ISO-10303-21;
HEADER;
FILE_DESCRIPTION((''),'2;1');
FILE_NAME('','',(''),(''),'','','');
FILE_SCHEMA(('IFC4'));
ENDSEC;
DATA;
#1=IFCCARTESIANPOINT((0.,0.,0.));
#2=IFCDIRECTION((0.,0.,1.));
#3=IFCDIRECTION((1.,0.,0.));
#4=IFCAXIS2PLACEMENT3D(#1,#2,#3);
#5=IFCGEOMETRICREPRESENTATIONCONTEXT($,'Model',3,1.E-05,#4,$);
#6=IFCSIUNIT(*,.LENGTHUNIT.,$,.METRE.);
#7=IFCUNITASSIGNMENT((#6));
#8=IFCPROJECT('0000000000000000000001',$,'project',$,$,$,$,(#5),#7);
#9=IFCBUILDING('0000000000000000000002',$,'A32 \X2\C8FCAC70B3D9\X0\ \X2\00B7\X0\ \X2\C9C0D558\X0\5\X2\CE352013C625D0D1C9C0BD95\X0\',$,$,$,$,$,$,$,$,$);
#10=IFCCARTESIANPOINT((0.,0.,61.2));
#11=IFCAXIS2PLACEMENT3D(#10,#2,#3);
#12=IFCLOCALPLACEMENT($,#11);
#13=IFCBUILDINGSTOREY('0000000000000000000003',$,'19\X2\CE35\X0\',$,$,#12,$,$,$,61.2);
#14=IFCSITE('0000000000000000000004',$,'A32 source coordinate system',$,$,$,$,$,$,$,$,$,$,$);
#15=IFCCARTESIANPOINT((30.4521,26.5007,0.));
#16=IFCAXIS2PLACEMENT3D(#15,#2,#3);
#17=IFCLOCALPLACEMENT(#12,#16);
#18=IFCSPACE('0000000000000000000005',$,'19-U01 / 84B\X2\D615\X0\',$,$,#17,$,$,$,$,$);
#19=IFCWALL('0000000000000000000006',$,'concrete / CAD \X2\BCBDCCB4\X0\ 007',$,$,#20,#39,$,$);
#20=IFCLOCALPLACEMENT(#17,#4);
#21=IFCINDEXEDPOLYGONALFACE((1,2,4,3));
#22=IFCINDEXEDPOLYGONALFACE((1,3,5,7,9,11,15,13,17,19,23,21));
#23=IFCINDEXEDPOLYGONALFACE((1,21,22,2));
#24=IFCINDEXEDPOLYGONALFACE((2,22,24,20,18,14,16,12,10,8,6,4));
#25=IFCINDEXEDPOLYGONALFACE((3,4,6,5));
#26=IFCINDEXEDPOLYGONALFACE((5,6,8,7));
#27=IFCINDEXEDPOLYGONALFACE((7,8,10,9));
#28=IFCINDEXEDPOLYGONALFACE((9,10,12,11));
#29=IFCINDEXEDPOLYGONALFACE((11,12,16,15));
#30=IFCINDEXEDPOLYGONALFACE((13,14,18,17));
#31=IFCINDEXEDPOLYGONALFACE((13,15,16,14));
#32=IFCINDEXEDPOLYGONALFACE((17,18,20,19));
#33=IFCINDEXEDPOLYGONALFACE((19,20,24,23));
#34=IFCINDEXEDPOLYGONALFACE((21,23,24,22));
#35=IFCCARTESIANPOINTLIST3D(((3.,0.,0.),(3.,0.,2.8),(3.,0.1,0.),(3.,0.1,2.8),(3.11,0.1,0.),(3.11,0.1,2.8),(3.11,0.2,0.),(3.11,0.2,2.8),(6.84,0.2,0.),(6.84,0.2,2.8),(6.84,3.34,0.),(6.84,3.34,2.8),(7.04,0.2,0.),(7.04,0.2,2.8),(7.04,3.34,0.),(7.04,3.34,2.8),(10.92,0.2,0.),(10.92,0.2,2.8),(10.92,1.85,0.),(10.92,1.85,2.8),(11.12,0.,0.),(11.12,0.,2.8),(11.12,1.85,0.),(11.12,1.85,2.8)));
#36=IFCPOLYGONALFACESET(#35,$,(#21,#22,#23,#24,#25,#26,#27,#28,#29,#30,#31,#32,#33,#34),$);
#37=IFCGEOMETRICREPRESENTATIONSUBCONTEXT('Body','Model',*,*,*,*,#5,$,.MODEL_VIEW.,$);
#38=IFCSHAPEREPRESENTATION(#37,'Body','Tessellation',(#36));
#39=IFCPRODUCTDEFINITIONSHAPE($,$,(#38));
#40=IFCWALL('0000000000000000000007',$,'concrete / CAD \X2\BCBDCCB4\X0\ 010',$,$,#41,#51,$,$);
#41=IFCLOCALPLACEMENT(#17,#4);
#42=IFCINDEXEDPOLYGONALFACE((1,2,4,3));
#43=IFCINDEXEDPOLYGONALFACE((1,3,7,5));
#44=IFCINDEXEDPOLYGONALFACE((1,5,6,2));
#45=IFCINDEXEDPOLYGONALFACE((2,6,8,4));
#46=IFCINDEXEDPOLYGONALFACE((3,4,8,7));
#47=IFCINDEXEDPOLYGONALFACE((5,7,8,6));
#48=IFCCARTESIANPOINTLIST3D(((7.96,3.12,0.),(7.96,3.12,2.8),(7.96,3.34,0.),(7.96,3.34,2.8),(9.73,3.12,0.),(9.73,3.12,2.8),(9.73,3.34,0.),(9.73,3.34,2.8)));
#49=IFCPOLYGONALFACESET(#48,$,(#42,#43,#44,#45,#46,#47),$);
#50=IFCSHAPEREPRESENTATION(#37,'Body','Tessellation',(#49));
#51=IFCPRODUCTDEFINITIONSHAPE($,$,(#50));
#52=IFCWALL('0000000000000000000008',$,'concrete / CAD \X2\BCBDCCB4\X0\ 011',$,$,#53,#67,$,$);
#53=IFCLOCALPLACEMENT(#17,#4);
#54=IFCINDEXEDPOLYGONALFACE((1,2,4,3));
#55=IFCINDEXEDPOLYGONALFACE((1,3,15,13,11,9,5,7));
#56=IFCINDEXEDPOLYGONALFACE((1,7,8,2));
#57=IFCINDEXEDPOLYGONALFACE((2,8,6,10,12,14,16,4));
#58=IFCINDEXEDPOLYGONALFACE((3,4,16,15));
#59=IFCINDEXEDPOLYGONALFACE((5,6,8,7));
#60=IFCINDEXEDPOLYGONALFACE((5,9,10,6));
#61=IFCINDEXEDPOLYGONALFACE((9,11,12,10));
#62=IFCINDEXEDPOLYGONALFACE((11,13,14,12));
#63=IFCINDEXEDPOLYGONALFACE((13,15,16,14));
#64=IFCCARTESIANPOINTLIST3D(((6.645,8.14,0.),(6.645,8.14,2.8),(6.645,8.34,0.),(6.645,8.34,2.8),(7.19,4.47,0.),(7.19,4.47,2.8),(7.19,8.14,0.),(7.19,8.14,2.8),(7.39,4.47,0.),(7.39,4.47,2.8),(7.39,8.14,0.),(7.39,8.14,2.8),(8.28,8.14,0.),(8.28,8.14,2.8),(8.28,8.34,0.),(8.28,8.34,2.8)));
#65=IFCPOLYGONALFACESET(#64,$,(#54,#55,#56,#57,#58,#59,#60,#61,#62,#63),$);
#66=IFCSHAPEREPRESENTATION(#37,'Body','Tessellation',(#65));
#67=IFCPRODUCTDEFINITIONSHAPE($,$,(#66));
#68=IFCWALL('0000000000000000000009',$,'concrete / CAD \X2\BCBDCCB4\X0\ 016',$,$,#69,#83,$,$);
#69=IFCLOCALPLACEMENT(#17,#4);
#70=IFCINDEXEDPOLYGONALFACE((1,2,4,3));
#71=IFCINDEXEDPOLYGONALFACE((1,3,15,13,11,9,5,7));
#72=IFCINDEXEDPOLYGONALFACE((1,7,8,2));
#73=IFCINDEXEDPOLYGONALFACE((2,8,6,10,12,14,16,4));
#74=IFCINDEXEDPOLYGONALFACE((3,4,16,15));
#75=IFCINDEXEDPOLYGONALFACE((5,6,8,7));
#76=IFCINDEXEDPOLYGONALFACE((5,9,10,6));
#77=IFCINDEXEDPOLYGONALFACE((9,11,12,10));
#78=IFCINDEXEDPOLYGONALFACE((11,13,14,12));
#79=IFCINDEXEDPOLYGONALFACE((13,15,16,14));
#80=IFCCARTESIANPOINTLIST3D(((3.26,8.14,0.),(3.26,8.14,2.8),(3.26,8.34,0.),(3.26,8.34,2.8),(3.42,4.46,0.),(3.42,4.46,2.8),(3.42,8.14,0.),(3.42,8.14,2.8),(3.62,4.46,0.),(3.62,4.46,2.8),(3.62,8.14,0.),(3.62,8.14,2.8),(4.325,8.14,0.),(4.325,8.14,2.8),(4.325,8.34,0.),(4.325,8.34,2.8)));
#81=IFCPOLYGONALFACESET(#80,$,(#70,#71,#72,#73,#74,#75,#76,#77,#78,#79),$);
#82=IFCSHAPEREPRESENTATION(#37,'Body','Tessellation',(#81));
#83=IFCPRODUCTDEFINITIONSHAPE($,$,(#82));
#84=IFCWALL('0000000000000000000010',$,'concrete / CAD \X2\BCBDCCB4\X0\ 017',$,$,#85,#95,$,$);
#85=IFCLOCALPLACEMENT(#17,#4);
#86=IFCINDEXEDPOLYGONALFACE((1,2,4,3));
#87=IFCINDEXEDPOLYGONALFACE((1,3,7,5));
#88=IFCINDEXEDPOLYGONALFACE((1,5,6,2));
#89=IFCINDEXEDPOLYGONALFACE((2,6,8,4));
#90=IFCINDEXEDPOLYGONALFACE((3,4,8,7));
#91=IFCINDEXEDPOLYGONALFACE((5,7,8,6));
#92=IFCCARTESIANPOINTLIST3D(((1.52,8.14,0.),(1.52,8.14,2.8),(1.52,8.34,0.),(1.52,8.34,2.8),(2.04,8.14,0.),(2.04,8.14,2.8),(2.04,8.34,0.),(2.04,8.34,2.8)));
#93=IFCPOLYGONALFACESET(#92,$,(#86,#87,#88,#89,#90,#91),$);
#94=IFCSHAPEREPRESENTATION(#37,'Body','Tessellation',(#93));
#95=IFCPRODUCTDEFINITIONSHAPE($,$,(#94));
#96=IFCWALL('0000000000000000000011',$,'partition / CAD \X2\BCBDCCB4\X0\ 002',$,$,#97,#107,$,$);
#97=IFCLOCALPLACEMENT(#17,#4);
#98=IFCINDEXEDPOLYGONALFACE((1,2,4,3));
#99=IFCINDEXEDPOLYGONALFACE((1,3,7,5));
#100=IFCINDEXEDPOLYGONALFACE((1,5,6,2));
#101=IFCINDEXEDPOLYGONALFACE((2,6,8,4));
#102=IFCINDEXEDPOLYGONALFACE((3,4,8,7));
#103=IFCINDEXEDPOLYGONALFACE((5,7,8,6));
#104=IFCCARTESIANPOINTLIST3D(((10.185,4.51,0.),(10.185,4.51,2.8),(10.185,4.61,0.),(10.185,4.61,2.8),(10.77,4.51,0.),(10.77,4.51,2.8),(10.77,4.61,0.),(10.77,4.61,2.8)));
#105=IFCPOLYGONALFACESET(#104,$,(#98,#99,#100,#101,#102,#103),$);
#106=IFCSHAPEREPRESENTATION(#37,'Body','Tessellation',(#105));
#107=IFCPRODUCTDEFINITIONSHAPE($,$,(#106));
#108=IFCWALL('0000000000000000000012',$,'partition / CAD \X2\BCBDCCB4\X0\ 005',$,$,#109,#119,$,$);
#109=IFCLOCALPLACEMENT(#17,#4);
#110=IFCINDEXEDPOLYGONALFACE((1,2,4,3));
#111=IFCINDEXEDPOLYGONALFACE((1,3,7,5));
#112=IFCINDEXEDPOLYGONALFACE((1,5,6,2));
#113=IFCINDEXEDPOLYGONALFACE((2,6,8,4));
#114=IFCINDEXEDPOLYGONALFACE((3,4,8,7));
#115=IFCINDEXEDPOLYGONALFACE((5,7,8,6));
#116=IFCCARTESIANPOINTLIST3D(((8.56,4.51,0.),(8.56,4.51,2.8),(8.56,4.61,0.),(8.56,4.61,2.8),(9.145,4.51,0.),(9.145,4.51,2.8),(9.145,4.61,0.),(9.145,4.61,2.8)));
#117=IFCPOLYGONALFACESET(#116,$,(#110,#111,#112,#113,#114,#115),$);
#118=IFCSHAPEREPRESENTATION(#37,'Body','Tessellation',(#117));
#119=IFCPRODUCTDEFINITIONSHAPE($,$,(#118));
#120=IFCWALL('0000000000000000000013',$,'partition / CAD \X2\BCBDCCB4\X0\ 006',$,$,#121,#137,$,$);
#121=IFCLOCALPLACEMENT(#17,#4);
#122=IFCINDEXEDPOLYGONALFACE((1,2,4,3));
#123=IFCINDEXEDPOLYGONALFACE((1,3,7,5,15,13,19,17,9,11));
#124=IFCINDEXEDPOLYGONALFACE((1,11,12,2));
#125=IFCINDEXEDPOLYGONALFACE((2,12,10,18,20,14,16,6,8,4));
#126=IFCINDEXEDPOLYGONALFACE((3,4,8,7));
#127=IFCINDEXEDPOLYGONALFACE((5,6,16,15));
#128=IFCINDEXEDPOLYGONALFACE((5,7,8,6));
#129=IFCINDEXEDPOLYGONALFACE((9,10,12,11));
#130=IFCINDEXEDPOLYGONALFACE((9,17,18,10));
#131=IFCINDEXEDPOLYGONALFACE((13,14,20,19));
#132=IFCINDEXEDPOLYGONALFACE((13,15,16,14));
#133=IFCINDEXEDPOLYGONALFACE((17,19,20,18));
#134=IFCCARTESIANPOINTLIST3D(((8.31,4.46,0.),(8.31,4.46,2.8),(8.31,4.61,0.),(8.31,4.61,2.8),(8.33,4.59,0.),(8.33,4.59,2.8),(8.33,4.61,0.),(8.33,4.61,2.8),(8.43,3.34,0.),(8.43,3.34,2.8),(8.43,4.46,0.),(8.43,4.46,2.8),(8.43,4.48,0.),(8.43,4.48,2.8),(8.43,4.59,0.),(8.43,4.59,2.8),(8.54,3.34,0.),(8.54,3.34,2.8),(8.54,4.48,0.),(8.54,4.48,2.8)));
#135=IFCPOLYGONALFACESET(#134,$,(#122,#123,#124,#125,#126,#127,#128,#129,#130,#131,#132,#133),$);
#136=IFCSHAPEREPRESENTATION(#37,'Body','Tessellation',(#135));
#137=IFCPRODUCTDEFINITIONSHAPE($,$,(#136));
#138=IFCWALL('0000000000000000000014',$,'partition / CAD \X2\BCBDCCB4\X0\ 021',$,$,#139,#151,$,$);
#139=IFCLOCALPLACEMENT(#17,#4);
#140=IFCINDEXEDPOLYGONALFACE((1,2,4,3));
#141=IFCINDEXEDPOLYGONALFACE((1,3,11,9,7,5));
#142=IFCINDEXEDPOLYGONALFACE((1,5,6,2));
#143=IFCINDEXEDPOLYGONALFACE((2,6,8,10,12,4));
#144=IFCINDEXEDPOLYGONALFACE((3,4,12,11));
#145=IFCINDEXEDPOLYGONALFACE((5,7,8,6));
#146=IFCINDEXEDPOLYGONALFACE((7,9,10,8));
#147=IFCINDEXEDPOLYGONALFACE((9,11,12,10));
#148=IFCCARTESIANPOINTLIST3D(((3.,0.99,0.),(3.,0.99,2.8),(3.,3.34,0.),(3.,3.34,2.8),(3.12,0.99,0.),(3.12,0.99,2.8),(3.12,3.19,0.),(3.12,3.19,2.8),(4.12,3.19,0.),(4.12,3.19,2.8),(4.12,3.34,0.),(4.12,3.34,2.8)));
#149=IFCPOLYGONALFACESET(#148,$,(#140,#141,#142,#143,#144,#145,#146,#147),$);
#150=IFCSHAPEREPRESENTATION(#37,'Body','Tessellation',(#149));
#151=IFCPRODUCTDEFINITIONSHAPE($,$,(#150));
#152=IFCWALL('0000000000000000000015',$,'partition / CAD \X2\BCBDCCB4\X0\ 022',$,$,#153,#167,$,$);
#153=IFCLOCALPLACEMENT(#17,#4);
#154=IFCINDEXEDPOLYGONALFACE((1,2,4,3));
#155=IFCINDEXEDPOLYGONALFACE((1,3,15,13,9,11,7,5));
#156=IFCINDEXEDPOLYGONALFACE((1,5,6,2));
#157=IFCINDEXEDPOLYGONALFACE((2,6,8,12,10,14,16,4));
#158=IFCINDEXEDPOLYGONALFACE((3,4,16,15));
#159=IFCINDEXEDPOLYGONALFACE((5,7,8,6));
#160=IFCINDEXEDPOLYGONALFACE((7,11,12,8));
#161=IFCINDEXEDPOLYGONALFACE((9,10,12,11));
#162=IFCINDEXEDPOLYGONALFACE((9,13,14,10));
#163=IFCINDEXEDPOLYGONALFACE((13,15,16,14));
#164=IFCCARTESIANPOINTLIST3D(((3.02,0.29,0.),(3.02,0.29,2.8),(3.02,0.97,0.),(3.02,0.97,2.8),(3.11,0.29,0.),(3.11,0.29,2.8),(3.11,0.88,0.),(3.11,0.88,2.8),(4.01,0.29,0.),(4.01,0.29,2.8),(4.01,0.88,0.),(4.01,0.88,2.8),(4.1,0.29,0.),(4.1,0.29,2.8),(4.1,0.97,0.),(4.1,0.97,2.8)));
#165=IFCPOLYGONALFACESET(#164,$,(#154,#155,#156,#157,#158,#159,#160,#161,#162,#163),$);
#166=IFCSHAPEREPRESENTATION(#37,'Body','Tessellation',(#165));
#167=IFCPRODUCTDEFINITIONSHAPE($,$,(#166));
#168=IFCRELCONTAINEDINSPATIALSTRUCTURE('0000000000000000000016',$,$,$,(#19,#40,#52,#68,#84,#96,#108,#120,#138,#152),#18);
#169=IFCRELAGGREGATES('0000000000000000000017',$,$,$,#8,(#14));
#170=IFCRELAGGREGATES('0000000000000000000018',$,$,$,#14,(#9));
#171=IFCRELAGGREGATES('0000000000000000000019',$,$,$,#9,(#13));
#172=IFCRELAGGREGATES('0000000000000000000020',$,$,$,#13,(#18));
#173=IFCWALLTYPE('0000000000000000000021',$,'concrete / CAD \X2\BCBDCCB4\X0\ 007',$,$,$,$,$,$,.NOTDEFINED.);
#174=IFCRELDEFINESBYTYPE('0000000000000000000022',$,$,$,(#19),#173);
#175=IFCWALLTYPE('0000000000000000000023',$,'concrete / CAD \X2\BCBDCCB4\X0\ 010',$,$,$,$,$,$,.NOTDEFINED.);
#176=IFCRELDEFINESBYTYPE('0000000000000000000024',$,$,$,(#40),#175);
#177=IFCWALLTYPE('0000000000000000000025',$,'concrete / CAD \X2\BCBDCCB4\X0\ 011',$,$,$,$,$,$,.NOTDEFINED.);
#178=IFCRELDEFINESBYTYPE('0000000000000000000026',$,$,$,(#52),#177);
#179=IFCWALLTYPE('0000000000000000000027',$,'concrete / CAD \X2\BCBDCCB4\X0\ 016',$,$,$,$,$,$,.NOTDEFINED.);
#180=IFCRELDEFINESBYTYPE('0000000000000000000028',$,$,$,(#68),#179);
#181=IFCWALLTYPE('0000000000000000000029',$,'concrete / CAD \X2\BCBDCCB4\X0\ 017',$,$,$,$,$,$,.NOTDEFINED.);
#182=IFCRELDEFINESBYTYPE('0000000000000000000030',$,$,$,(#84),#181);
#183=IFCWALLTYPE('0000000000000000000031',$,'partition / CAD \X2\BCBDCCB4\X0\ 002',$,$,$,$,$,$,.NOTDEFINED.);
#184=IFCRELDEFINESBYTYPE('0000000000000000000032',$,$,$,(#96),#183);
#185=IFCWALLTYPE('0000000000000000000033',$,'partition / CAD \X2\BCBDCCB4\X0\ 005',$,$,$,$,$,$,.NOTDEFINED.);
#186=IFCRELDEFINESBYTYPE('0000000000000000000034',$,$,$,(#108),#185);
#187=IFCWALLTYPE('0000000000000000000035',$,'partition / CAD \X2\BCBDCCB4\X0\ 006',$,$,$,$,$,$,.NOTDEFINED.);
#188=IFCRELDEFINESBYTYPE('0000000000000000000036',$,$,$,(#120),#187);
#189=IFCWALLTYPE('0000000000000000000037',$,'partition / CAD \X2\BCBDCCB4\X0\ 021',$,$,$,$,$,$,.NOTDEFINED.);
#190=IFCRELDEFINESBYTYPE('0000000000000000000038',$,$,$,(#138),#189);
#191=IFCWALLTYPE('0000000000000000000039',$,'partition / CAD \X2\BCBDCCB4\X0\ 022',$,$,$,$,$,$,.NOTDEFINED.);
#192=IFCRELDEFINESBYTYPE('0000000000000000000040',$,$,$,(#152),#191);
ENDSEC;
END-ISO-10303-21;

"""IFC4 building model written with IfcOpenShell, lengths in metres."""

from ifc_helpers import new_model, si_unit, frame, origin, origin_with_axes, place, context, subcontext, project, spatial, polyline, outline, extrude, source, transform, mapped, type_object, type_shapes, element, save


model = new_model("IFC4")

# Units and contexts
model_context = context("Model", 3, precision=1e-05, world=origin_with_axes())
body_context = subcontext(model_context, "Body", "Model", "MODEL_VIEW")
ifc_project = project(units=[si_unit("LENGTHUNIT", "METRE")], contexts=[model_context])

# Site, building, storey, space
site = spatial("IfcSite", under=ifc_project, Name="A32 source coordinate system")
building = spatial("IfcBuilding", under=site, Name="A32 주거동 · 지하5층–옥탑지붕")
storey_placement = place(None, frame((0.0, 0.0, 61.2), z_axis=(0.0, 0.0, 1.0), x_axis=(1.0, 0.0, 0.0)))
storey = spatial("IfcBuildingStorey", under=building, at=storey_placement, Name="19층", Elevation=61.2)
space_1_placement = place(storey_placement, frame((30.4521, 26.5007, 0.0), z_axis=(0.0, 0.0, 1.0), x_axis=(1.0, 0.0, 0.0)))
space_1 = spatial("IfcSpace", under=storey, at=space_1_placement, Name="19-U01 / 84B형")

# Walls
wall_type_1 = type_object("IfcWallType", Name="concrete / CAD 벽체 007", PredefinedType="NOTDEFINED")
shared_shape_1 = source(origin(), body_context, "Body", "SweptSolid", [
    extrude(outline(polyline([(3.0, 0.0), (3.0, 0.1), (3.11, 0.1), (3.11, 0.2), (6.84, 0.2), (6.84, 3.34), (7.04, 3.34), (7.04, 0.2), (10.92, 0.2), (10.92, 1.85), (11.12, 1.85), (11.12, 0.0), (3.0, 0.0)])), origin(), (0.0, 0.0, 1.0), 2.8),
])
type_shapes(wall_type_1, [shared_shape_1])
wall_1_placement = place(space_1_placement, origin_with_axes())
element("IfcWall", 1, at=wall_1_placement, inside=space_1, type_object=wall_type_1, Name="concrete / CAD 벽체 007", context=body_context, shape_type="MappedRepresentation", body=[
    mapped(shared_shape_1, transform((0.0, 0.0, 0.0), scale=1.0)),
])
wall_type_2 = type_object("IfcWallType", Name="concrete / CAD 벽체 010", PredefinedType="NOTDEFINED")
shared_shape_2 = source(origin(), body_context, "Body", "SweptSolid", [
    extrude(outline(polyline([(7.96, 3.12), (7.96, 3.34), (9.73, 3.34), (9.73, 3.12), (7.96, 3.12)])), origin(), (0.0, 0.0, 1.0), 2.8),
])
type_shapes(wall_type_2, [shared_shape_2])
wall_2_placement = place(space_1_placement, origin_with_axes())
element("IfcWall", 2, at=wall_2_placement, inside=space_1, type_object=wall_type_2, Name="concrete / CAD 벽체 010", context=body_context, shape_type="MappedRepresentation", body=[
    mapped(shared_shape_2, transform((0.0, 0.0, 0.0), scale=1.0)),
])
wall_type_3 = type_object("IfcWallType", Name="concrete / CAD 벽체 011", PredefinedType="NOTDEFINED")
shared_shape_3 = source(origin(), body_context, "Body", "SweptSolid", [
    extrude(outline(polyline([(7.19, 8.14), (6.645, 8.14), (6.645, 8.34), (8.28, 8.34), (8.28, 8.14), (7.39, 8.14), (7.39, 4.47), (7.19, 4.47), (7.19, 8.14)])), origin(), (0.0, 0.0, 1.0), 2.8),
])
type_shapes(wall_type_3, [shared_shape_3])
wall_3_placement = place(space_1_placement, origin_with_axes())
element("IfcWall", 3, at=wall_3_placement, inside=space_1, type_object=wall_type_3, Name="concrete / CAD 벽체 011", context=body_context, shape_type="MappedRepresentation", body=[
    mapped(shared_shape_3, transform((0.0, 0.0, 0.0), scale=1.0)),
])
wall_type_4 = type_object("IfcWallType", Name="concrete / CAD 벽체 016", PredefinedType="NOTDEFINED")
shared_shape_4 = source(origin(), body_context, "Body", "SweptSolid", [
    extrude(outline(polyline([(3.26, 8.14), (3.26, 8.34), (4.325, 8.34), (4.325, 8.14), (3.62, 8.14), (3.62, 4.46), (3.42, 4.46), (3.42, 8.14), (3.26, 8.14)])), origin(), (0.0, 0.0, 1.0), 2.8),
])
type_shapes(wall_type_4, [shared_shape_4])
wall_4_placement = place(space_1_placement, origin_with_axes())
element("IfcWall", 4, at=wall_4_placement, inside=space_1, type_object=wall_type_4, Name="concrete / CAD 벽체 016", context=body_context, shape_type="MappedRepresentation", body=[
    mapped(shared_shape_4, transform((0.0, 0.0, 0.0), scale=1.0)),
])
wall_type_5 = type_object("IfcWallType", Name="concrete / CAD 벽체 017", PredefinedType="NOTDEFINED")
shared_shape_5 = source(origin(), body_context, "Body", "SweptSolid", [
    extrude(outline(polyline([(1.52, 8.34), (2.04, 8.34), (2.04, 8.14), (1.52, 8.14), (1.52, 8.34)])), origin(), (0.0, 0.0, 1.0), 2.8),
])
type_shapes(wall_type_5, [shared_shape_5])
wall_5_placement = place(space_1_placement, origin_with_axes())
element("IfcWall", 5, at=wall_5_placement, inside=space_1, type_object=wall_type_5, Name="concrete / CAD 벽체 017", context=body_context, shape_type="MappedRepresentation", body=[
    mapped(shared_shape_5, transform((0.0, 0.0, 0.0), scale=1.0)),
])
wall_type_6 = type_object("IfcWallType", Name="partition / CAD 벽체 002", PredefinedType="NOTDEFINED")
shared_shape_6 = source(origin(), body_context, "Body", "SweptSolid", [
    extrude(outline(polyline([(10.185, 4.51), (10.185, 4.61), (10.77, 4.61), (10.77, 4.51), (10.185, 4.51)])), origin(), (0.0, 0.0, 1.0), 2.8),
])
type_shapes(wall_type_6, [shared_shape_6])
wall_6_placement = place(space_1_placement, origin_with_axes())
element("IfcWall", 6, at=wall_6_placement, inside=space_1, type_object=wall_type_6, Name="partition / CAD 벽체 002", context=body_context, shape_type="MappedRepresentation", body=[
    mapped(shared_shape_6, transform((0.0, 0.0, 0.0), scale=1.0)),
])
wall_type_7 = type_object("IfcWallType", Name="partition / CAD 벽체 005", PredefinedType="NOTDEFINED")
shared_shape_7 = source(origin(), body_context, "Body", "SweptSolid", [
    extrude(outline(polyline([(8.56, 4.51), (8.56, 4.61), (9.145, 4.61), (9.145, 4.51), (8.56, 4.51)])), origin(), (0.0, 0.0, 1.0), 2.8),
])
type_shapes(wall_type_7, [shared_shape_7])
wall_7_placement = place(space_1_placement, origin_with_axes())
element("IfcWall", 7, at=wall_7_placement, inside=space_1, type_object=wall_type_7, Name="partition / CAD 벽체 005", context=body_context, shape_type="MappedRepresentation", body=[
    mapped(shared_shape_7, transform((0.0, 0.0, 0.0), scale=1.0)),
])
wall_type_8 = type_object("IfcWallType", Name="partition / CAD 벽체 006", PredefinedType="NOTDEFINED")
shared_shape_8 = source(origin(), body_context, "Body", "SweptSolid", [
    extrude(outline(polyline([(8.43, 4.46), (8.31, 4.46), (8.31, 4.61), (8.33, 4.61), (8.33, 4.59), (8.43, 4.59), (8.43, 4.48), (8.54, 4.48), (8.54, 3.34), (8.43, 3.34), (8.43, 4.46)])), origin(), (0.0, 0.0, 1.0), 2.8),
])
type_shapes(wall_type_8, [shared_shape_8])
wall_8_placement = place(space_1_placement, origin_with_axes())
element("IfcWall", 8, at=wall_8_placement, inside=space_1, type_object=wall_type_8, Name="partition / CAD 벽체 006", context=body_context, shape_type="MappedRepresentation", body=[
    mapped(shared_shape_8, transform((0.0, 0.0, 0.0), scale=1.0)),
])
wall_type_9 = type_object("IfcWallType", Name="partition / CAD 벽체 021", PredefinedType="NOTDEFINED")
shared_shape_9 = source(origin(), body_context, "Body", "SweptSolid", [
    extrude(outline(polyline([(4.12, 3.34), (4.12, 3.19), (3.12, 3.19), (3.12, 0.99), (3.0, 0.99), (3.0, 3.34), (4.12, 3.34)])), origin(), (0.0, 0.0, 1.0), 2.8),
])
type_shapes(wall_type_9, [shared_shape_9])
wall_9_placement = place(space_1_placement, origin_with_axes())
element("IfcWall", 9, at=wall_9_placement, inside=space_1, type_object=wall_type_9, Name="partition / CAD 벽체 021", context=body_context, shape_type="MappedRepresentation", body=[
    mapped(shared_shape_9, transform((0.0, 0.0, 0.0), scale=1.0)),
])
wall_type_10 = type_object("IfcWallType", Name="partition / CAD 벽체 022", PredefinedType="NOTDEFINED")
shared_shape_10 = source(origin(), body_context, "Body", "SweptSolid", [
    extrude(outline(polyline([(4.1, 0.97), (4.1, 0.29), (4.01, 0.29), (4.01, 0.88), (3.11, 0.88), (3.11, 0.29), (3.02, 0.29), (3.02, 0.97), (4.1, 0.97)])), origin(), (0.0, 0.0, 1.0), 2.8),
])
type_shapes(wall_type_10, [shared_shape_10])
wall_10_placement = place(space_1_placement, origin_with_axes())
element("IfcWall", 10, at=wall_10_placement, inside=space_1, type_object=wall_type_10, Name="partition / CAD 벽체 022", context=body_context, shape_type="MappedRepresentation", body=[
    mapped(shared_shape_10, transform((0.0, 0.0, 0.0), scale=1.0)),
])

save(model, "model.ifc")
